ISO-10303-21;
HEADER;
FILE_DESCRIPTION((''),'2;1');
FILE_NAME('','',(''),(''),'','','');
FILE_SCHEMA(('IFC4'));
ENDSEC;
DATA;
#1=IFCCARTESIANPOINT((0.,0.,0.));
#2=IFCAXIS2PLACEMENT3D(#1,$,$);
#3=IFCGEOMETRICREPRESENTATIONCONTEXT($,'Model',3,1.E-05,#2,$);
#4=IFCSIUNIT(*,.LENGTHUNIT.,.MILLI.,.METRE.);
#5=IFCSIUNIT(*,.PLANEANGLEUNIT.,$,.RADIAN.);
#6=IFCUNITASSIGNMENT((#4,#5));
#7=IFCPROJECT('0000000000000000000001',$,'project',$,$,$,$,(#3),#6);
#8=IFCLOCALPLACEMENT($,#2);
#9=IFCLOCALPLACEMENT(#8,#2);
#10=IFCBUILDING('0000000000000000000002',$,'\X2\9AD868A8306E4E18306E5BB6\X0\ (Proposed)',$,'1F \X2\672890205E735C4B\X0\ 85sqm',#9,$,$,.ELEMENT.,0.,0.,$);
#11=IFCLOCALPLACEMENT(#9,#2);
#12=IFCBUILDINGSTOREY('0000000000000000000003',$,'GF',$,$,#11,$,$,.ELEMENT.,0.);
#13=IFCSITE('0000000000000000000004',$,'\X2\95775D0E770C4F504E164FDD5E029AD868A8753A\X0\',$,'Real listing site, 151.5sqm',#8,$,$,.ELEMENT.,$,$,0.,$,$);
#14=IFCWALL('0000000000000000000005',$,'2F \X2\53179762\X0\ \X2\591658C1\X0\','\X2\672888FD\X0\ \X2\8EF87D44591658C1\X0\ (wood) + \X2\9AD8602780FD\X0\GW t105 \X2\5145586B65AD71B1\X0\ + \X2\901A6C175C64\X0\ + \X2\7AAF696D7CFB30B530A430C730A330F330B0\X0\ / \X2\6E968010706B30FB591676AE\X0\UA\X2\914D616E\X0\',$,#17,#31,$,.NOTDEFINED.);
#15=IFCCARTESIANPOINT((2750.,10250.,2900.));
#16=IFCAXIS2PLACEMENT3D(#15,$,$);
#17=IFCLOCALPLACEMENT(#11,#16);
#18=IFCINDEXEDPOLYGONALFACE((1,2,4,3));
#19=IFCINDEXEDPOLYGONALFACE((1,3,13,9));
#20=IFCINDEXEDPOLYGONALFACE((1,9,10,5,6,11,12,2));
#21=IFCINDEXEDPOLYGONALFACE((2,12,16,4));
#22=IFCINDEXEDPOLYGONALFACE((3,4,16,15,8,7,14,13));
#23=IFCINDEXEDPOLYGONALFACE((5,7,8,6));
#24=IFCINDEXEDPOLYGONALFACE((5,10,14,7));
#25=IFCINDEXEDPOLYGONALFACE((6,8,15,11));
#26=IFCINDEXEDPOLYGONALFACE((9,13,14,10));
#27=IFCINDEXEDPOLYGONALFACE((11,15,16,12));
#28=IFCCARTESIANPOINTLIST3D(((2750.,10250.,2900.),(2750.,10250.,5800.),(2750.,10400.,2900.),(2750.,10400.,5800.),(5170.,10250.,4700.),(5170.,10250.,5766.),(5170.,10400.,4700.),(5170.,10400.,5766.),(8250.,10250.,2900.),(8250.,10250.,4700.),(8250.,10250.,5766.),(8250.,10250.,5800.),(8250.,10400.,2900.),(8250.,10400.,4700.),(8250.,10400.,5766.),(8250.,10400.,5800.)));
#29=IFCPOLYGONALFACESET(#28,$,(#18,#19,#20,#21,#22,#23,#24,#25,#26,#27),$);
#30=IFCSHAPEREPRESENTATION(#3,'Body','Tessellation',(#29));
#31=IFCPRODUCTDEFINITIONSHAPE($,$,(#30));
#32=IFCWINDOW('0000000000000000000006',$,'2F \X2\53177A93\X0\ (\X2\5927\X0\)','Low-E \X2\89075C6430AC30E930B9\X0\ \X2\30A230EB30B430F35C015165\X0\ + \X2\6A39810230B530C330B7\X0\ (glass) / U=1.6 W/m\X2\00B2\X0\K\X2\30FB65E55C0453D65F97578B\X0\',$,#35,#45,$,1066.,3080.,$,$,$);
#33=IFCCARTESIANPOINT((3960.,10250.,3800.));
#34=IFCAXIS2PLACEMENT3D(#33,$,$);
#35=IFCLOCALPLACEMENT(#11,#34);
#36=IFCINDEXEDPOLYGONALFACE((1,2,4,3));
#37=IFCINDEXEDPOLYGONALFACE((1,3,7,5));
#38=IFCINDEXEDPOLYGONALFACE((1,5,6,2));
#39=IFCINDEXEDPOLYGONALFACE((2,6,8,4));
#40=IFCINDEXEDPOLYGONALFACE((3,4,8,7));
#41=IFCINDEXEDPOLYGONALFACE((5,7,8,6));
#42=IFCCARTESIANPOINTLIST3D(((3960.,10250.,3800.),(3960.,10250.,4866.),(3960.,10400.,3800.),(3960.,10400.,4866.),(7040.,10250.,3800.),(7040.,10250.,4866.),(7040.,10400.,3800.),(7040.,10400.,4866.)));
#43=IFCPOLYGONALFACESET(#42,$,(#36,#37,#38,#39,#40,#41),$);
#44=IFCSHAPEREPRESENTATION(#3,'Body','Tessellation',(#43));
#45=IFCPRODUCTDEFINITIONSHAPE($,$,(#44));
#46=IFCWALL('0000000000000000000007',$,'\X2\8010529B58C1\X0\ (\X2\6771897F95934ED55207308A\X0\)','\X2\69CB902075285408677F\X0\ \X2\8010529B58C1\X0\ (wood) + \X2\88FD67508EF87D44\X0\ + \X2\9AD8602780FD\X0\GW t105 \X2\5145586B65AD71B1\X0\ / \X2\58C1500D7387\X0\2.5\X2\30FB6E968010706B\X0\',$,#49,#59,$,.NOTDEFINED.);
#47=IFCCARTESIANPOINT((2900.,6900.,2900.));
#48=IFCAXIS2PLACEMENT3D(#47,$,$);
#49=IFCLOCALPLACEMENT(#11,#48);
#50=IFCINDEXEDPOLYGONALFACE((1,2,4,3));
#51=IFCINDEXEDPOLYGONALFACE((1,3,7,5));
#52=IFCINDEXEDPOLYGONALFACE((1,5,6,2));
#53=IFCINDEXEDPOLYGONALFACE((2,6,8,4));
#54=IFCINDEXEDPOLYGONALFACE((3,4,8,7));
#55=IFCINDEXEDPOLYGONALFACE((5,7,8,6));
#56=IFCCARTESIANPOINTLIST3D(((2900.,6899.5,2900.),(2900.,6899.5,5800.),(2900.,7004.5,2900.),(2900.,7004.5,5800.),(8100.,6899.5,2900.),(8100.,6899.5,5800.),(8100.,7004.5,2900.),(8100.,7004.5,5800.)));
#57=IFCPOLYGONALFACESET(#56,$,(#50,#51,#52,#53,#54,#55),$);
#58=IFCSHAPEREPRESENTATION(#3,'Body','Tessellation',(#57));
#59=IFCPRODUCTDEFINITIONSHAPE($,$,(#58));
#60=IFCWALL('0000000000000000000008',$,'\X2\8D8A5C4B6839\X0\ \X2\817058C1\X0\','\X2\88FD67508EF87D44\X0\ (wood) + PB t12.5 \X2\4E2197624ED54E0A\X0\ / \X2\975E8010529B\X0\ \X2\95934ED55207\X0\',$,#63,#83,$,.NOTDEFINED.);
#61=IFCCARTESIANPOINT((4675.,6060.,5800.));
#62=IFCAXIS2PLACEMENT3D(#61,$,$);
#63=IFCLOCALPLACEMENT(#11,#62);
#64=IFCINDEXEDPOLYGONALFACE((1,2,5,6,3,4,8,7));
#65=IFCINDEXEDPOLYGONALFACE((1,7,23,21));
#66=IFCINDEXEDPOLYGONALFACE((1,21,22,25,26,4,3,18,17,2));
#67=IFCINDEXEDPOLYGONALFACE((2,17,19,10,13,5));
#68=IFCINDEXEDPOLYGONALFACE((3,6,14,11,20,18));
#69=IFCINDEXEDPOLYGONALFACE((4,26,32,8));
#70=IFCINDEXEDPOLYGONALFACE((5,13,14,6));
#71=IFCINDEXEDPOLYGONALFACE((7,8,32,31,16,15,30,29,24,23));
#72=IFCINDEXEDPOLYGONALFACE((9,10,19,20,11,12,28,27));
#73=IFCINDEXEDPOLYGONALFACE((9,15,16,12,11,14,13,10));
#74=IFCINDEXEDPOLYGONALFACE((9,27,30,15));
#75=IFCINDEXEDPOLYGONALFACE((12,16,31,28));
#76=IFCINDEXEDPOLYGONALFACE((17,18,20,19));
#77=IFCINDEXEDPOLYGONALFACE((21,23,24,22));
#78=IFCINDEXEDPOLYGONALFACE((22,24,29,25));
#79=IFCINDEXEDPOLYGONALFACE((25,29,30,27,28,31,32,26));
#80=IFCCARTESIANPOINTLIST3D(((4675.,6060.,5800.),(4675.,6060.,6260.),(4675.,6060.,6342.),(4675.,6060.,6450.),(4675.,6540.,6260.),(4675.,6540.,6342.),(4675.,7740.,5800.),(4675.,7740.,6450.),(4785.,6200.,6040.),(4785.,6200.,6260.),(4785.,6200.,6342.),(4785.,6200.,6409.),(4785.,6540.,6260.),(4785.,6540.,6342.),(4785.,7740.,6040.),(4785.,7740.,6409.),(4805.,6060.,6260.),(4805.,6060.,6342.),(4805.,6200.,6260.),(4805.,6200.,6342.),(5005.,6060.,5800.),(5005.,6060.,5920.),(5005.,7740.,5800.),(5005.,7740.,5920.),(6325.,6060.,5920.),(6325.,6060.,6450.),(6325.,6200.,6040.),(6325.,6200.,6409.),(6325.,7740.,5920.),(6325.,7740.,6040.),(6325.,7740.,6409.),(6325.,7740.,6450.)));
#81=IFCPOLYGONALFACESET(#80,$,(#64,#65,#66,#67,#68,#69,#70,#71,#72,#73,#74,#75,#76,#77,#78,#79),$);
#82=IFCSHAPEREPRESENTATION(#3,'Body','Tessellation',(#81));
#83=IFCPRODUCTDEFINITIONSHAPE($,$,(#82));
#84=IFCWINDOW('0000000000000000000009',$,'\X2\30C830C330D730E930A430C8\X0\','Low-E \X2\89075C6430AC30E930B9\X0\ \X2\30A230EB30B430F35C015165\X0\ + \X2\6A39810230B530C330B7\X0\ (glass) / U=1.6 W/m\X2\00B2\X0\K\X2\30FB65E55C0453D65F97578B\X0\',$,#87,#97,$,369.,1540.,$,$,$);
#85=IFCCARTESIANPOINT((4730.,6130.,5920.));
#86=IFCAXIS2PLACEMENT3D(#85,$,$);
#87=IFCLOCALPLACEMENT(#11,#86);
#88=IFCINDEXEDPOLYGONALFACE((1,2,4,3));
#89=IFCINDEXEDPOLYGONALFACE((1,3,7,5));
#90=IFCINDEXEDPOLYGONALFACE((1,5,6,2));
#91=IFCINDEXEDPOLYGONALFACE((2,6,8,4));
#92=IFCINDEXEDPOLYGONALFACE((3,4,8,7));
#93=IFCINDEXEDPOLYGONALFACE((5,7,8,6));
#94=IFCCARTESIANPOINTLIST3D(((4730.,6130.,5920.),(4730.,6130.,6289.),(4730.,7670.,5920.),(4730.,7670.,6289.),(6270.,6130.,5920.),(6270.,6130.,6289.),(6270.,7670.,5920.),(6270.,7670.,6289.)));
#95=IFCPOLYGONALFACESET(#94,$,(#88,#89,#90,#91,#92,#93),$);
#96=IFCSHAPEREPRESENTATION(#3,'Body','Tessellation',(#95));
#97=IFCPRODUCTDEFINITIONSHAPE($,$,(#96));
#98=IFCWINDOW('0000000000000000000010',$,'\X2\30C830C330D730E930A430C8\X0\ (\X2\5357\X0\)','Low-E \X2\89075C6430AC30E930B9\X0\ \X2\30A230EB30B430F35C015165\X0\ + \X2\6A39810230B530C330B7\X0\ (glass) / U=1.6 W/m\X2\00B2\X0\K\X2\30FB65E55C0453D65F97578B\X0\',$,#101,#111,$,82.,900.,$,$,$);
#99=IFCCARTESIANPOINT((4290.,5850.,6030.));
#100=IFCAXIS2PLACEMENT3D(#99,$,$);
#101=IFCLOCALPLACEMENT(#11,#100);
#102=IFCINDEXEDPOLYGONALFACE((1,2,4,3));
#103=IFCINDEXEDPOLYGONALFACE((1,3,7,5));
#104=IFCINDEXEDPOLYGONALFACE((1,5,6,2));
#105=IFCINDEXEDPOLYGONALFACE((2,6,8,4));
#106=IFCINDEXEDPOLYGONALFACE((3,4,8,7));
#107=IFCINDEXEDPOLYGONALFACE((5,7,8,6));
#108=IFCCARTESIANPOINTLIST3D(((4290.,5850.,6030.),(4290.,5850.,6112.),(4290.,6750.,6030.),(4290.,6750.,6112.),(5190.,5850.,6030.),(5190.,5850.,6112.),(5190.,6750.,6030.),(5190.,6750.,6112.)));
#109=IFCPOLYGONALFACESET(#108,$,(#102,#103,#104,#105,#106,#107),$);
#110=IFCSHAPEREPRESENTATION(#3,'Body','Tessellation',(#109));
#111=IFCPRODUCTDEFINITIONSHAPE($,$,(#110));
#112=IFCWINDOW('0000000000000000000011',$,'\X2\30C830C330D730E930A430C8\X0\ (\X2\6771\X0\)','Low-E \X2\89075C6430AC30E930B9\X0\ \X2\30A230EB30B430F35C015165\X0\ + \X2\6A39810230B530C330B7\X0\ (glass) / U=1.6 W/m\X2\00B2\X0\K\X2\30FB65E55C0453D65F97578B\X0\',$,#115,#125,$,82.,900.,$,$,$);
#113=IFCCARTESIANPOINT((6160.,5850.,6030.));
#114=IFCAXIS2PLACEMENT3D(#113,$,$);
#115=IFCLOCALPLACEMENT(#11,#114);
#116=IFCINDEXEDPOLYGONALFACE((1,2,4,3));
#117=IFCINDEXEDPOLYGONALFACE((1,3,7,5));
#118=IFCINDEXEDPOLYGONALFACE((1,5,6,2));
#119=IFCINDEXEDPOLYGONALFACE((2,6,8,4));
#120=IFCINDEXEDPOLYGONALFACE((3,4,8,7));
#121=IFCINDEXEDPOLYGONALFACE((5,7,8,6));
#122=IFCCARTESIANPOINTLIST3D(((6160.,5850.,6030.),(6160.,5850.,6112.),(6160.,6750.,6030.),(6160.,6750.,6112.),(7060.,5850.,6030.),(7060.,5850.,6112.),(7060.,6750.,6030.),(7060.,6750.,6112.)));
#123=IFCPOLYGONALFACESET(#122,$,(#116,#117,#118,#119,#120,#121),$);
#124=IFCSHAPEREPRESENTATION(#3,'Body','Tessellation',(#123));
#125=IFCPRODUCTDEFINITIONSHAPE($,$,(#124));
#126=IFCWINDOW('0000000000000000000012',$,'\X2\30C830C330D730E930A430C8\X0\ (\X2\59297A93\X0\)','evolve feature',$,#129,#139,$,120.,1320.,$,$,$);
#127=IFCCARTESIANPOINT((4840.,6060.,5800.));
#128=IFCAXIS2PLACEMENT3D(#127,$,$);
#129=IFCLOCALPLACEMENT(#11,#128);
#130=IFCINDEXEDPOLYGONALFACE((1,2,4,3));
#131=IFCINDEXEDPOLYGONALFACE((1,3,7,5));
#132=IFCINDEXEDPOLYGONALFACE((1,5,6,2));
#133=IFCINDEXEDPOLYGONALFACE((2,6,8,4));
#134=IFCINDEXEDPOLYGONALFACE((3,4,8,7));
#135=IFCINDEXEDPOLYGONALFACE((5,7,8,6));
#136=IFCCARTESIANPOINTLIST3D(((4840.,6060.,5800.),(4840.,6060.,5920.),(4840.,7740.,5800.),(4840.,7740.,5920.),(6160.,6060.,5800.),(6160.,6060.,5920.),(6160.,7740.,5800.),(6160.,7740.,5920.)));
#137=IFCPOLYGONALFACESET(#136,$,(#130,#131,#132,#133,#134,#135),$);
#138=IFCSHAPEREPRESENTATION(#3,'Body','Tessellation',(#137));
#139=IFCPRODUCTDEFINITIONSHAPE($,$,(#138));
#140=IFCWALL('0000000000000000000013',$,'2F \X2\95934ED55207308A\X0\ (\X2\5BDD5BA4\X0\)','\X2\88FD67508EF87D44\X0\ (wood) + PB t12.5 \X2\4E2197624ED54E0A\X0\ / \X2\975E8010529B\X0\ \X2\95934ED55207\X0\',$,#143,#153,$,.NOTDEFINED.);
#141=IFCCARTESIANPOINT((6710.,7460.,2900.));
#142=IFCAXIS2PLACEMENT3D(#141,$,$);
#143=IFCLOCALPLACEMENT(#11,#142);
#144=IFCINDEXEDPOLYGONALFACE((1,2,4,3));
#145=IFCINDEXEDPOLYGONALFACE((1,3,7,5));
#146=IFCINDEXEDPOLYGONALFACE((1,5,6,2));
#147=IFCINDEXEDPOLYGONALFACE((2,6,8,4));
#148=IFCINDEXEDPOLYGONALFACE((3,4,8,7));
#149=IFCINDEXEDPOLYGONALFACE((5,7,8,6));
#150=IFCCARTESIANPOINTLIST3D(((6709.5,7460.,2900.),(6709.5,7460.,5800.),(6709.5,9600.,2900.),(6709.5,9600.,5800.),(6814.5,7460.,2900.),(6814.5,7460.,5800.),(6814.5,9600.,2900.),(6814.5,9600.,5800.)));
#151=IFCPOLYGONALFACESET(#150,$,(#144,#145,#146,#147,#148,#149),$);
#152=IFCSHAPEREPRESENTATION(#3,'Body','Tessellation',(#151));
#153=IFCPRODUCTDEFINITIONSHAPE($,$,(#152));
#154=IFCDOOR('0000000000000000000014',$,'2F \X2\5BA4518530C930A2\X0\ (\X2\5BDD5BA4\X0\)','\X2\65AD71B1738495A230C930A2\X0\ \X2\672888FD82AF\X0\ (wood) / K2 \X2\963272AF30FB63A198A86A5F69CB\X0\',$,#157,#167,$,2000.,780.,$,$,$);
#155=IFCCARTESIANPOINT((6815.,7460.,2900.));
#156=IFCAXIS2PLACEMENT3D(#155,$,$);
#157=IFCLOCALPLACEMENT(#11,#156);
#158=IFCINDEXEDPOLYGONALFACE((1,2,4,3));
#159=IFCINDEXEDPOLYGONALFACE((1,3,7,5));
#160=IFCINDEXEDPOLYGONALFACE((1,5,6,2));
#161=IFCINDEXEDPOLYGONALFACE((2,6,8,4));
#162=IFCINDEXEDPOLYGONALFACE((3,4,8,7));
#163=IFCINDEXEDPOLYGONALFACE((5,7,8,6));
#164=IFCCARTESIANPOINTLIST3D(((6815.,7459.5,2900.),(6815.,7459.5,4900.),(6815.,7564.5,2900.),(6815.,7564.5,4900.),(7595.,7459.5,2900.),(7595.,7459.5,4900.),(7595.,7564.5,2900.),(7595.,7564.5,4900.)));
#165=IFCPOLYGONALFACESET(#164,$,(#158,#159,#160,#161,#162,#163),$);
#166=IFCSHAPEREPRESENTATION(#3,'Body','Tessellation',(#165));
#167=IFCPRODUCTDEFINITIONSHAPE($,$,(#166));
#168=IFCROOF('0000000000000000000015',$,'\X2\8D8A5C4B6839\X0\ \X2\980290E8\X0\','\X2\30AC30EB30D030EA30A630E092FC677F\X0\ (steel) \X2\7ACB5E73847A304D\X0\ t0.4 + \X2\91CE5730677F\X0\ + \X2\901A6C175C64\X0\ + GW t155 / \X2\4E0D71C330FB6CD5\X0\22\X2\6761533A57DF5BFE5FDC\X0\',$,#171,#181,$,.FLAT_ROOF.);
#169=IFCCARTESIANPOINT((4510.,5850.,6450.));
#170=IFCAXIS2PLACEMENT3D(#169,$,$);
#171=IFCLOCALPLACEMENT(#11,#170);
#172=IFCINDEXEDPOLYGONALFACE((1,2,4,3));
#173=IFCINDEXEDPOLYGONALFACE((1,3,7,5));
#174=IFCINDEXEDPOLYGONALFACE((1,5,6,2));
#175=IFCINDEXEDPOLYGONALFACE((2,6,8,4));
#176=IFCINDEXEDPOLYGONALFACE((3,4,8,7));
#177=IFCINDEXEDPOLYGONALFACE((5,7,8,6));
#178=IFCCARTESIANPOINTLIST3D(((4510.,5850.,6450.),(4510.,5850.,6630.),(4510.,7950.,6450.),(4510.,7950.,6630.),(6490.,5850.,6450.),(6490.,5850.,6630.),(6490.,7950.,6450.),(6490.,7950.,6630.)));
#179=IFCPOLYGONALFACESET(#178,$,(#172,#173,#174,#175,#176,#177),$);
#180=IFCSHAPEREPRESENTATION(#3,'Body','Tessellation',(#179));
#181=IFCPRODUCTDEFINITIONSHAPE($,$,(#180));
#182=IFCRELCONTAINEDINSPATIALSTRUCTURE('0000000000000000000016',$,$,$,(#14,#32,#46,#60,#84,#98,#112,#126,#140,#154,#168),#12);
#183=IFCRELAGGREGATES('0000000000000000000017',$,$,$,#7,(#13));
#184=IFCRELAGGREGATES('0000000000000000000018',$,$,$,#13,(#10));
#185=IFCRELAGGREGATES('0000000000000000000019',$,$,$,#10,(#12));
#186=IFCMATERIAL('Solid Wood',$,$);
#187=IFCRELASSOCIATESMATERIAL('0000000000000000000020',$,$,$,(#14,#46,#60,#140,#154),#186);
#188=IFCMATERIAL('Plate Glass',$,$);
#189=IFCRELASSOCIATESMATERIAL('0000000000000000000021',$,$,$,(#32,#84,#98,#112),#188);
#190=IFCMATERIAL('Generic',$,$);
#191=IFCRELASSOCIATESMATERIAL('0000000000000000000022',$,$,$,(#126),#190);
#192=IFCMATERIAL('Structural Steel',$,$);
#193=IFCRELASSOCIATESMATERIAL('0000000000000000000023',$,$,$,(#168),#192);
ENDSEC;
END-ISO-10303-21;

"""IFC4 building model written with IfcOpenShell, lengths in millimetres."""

from ifc_helpers import new_model, si_unit, frame, frame_2d, origin, place, context, project, spatial, rectangle, extrude, material, element, fill, save


model = new_model("IFC4")

# Units and contexts
model_context = context("Model", 3, precision=1e-05, world=origin())
ifc_project = project(units=[si_unit("LENGTHUNIT", "METRE", prefix="MILLI"), si_unit("PLANEANGLEUNIT", "RADIAN")], contexts=[model_context])

# Site, building, storey
site_placement = place(None, origin())
site = spatial("IfcSite", under=ifc_project, at=site_placement, Name="長崎県佐世保市高梨町", ObjectType="Real listing site, 151.5sqm", CompositionType="ELEMENT", RefElevation=0.0)
building_placement = place(site_placement, origin())
building = spatial("IfcBuilding", under=site, at=building_placement, Name="高梨の丘の家 (Proposed)", ObjectType="1F 木造平屋 85sqm", CompositionType="ELEMENT", ElevationOfRefHeight=0.0, ElevationOfTerrain=0.0)
storey_placement = place(building_placement, origin())
storey = spatial("IfcBuildingStorey", under=building, at=storey_placement, Name="GF", CompositionType="ELEMENT", Elevation=0.0)

# Wall, opening, window
ifc_material_1 = material(Name="Solid Wood")
wall_1_placement = place(storey_placement, frame((2750.0, 10250.0, 2900.0)))
wall_1 = element("IfcWall", 1, at=wall_1_placement, inside=storey, material=ifc_material_1, Name="2F 北面 外壁", Description="木製 軸組外壁 (wood) + 高性能GW t105 充填断熱 + 通気層 + 窯業系サイディング / 準耐火・外皮UA配慮", PredefinedType="NOTDEFINED", context=model_context, shape_type="SweptSolid", body=[
    extrude(rectangle(XDim=5500.0, YDim=150.0, at=frame_2d((2750.0, 75.0))), frame((2750.0, 10250.0, 2900.0)), (0.0, 0.0, 1.0), 2900.0),
])
opening_1_placement = place(storey_placement, frame((3960.0, 10250.0, 3800.0)))
opening_1 = element("IfcOpeningElement", 2, at=opening_1_placement, cuts=wall_1, PredefinedType="NOTDEFINED", context=model_context, shape_type="SweptSolid", body=[
    extrude(rectangle(XDim=3080.0, YDim=150.0, at=frame_2d((1540.0, 75.0))), frame((3960.0, 10250.0, 3800.0)), (0.0, 0.0, 1.0), 1066.0),
])
ifc_material_2 = material(Name="Plate Glass")
window_1_placement = place(storey_placement, frame((3960.0, 10250.0, 3800.0)))
window_1 = element("IfcWindow", 3, at=window_1_placement, inside=storey, material=ifc_material_2, Name="2F 北窓 (大)", Description="Low-E 複層ガラス アルゴン封入 + 樹脂サッシ (glass) / U=1.6 W/m²K・日射取得型", OverallHeight=1066.0, OverallWidth=3080.0, context=model_context, shape_type="SweptSolid", body=[
    extrude(rectangle(XDim=3080.0, YDim=150.0, at=frame_2d((1540.0, 75.0))), frame((3960.0, 10250.0, 3800.0)), (0.0, 0.0, 1.0), 1066.0),
])
fill(opening_1, window_1)

# Wall
wall_2_placement = place(storey_placement, frame((2900.0, 6900.0, 2900.0)))
element("IfcWall", 4, at=wall_2_placement, inside=storey, material=ifc_material_1, Name="耐力壁 (東西間仕切り)", Description="構造用合板 耐力壁 (wood) + 製材軸組 + 高性能GW t105 充填断熱 / 壁倍率2.5・準耐火", PredefinedType="NOTDEFINED", context=model_context, shape_type="SweptSolid", body=[
    extrude(rectangle(XDim=5200.0, YDim=105.0, at=frame_2d((2600.0, 52.0))), frame((2900.0, 6900.0, 2900.0)), (0.0, 0.0, 1.0), 2900.0),
])

# Wall, openings, windows
wall_3_placement = place(storey_placement, frame((4675.0, 6060.0, 5800.0)))
wall_3 = element("IfcWall", 5, at=wall_3_placement, inside=storey, material=ifc_material_1, Name="越屋根 腰壁", Description="製材軸組 (wood) + PB t12.5 両面仕上 / 非耐力 間仕切", PredefinedType="NOTDEFINED", context=model_context, shape_type="SweptSolid", body=[
    extrude(rectangle(XDim=1650.0, YDim=1680.0, at=frame_2d((825.0, 840.0))), frame((4675.0, 6060.0, 5800.0)), (0.0, 0.0, 1.0), 650.0),
])
opening_2_placement = place(storey_placement, frame((4730.0, 6130.0, 5920.0)))
opening_2 = element("IfcOpeningElement", 6, at=opening_2_placement, cuts=wall_3, PredefinedType="NOTDEFINED", context=model_context, shape_type="SweptSolid", body=[
    extrude(rectangle(XDim=1540.0, YDim=1540.0, at=frame_2d((770.0, 770.0))), frame((4730.0, 6130.0, 5920.0)), (0.0, 0.0, 1.0), 369.0),
])
opening_3_placement = place(storey_placement, frame((4290.0, 5850.0, 6030.0)))
opening_3 = element("IfcOpeningElement", 7, at=opening_3_placement, cuts=wall_3, PredefinedType="NOTDEFINED", context=model_context, shape_type="SweptSolid", body=[
    extrude(rectangle(XDim=900.0, YDim=900.0, at=frame_2d((450.0, 450.0))), frame((4290.0, 5850.0, 6030.0)), (0.0, 0.0, 1.0), 82.0),
])
opening_4_placement = place(storey_placement, frame((6160.0, 5850.0, 6030.0)))
opening_4 = element("IfcOpeningElement", 8, at=opening_4_placement, cuts=wall_3, PredefinedType="NOTDEFINED", context=model_context, shape_type="SweptSolid", body=[
    extrude(rectangle(XDim=900.0, YDim=900.0, at=frame_2d((450.0, 450.0))), frame((6160.0, 5850.0, 6030.0)), (0.0, 0.0, 1.0), 82.0),
])
opening_5_placement = place(storey_placement, frame((4840.0, 6060.0, 5800.0)))
opening_5 = element("IfcOpeningElement", 9, at=opening_5_placement, cuts=wall_3, PredefinedType="NOTDEFINED", context=model_context, shape_type="SweptSolid", body=[
    extrude(rectangle(XDim=1320.0, YDim=1680.0, at=frame_2d((660.0, 840.0))), frame((4840.0, 6060.0, 5800.0)), (0.0, 0.0, 1.0), 120.0),
])
window_2_placement = place(storey_placement, frame((4730.0, 6130.0, 5920.0)))
window_2 = element("IfcWindow", 10, at=window_2_placement, inside=storey, material=ifc_material_2, Name="トップライト", Description="Low-E 複層ガラス アルゴン封入 + 樹脂サッシ (glass) / U=1.6 W/m²K・日射取得型", OverallHeight=369.0, OverallWidth=1540.0, context=model_context, shape_type="SweptSolid", body=[
    extrude(rectangle(XDim=1540.0, YDim=1540.0, at=frame_2d((770.0, 770.0))), frame((4730.0, 6130.0, 5920.0)), (0.0, 0.0, 1.0), 369.0),
])
fill(opening_2, window_2)
window_3_placement = place(storey_placement, frame((4290.0, 5850.0, 6030.0)))
window_3 = element("IfcWindow", 11, at=window_3_placement, inside=storey, material=ifc_material_2, Name="トップライト (南)", Description="Low-E 複層ガラス アルゴン封入 + 樹脂サッシ (glass) / U=1.6 W/m²K・日射取得型", OverallHeight=82.0, OverallWidth=900.0, context=model_context, shape_type="SweptSolid", body=[
    extrude(rectangle(XDim=900.0, YDim=900.0, at=frame_2d((450.0, 450.0))), frame((4290.0, 5850.0, 6030.0)), (0.0, 0.0, 1.0), 82.0),
])
fill(opening_3, window_3)
window_4_placement = place(storey_placement, frame((6160.0, 5850.0, 6030.0)))
window_4 = element("IfcWindow", 12, at=window_4_placement, inside=storey, material=ifc_material_2, Name="トップライト (東)", Description="Low-E 複層ガラス アルゴン封入 + 樹脂サッシ (glass) / U=1.6 W/m²K・日射取得型", OverallHeight=82.0, OverallWidth=900.0, context=model_context, shape_type="SweptSolid", body=[
    extrude(rectangle(XDim=900.0, YDim=900.0, at=frame_2d((450.0, 450.0))), frame((6160.0, 5850.0, 6030.0)), (0.0, 0.0, 1.0), 82.0),
])
fill(opening_4, window_4)
ifc_material_3 = material(Name="Generic")
window_5_placement = place(storey_placement, frame((4840.0, 6060.0, 5800.0)))
window_5 = element("IfcWindow", 13, at=window_5_placement, inside=storey, material=ifc_material_3, Name="トップライト (天窓)", Description="evolve feature", OverallHeight=120.0, OverallWidth=1320.0, context=model_context, shape_type="SweptSolid", body=[
    extrude(rectangle(XDim=1320.0, YDim=1680.0, at=frame_2d((660.0, 840.0))), frame((4840.0, 6060.0, 5800.0)), (0.0, 0.0, 1.0), 120.0),
])
fill(opening_5, window_5)

# Wall
wall_4_placement = place(storey_placement, frame((6710.0, 7460.0, 2900.0)))
element("IfcWall", 14, at=wall_4_placement, inside=storey, material=ifc_material_1, Name="2F 間仕切り (寝室)", Description="製材軸組 (wood) + PB t12.5 両面仕上 / 非耐力 間仕切", PredefinedType="NOTDEFINED", context=model_context, shape_type="SweptSolid", body=[
    extrude(rectangle(XDim=105.0, YDim=2140.0, at=frame_2d((52.0, 1070.0))), frame((6710.0, 7460.0, 2900.0)), (0.0, 0.0, 1.0), 2900.0),
])

# Door
door_placement = place(storey_placement, frame((6815.0, 7460.0, 2900.0)))
element("IfcDoor", 15, at=door_placement, inside=storey, material=ifc_material_1, Name="2F 室内ドア (寝室)", Description="断熱玄関ドア 木製芯 (wood) / K2 防犯・採風機構", OverallHeight=2000.0, OverallWidth=780.0, context=model_context, shape_type="SweptSolid", body=[
    extrude(rectangle(XDim=780.0, YDim=105.0, at=frame_2d((390.0, 52.0))), frame((6815.0, 7460.0, 2900.0)), (0.0, 0.0, 1.0), 2000.0),
])

# Roof
ifc_material_4 = material(Name="Structural Steel")
roof_placement = place(storey_placement, frame((4510.0, 5850.0, 6450.0)))
element("IfcRoof", 16, at=roof_placement, inside=storey, material=ifc_material_4, Name="越屋根 頂部", Description="ガルバリウム鋼板 (steel) 立平葺き t0.4 + 野地板 + 通気層 + GW t155 / 不燃・法22条区域対応", PredefinedType="FLAT_ROOF", context=model_context, shape_type="SweptSolid", body=[
    extrude(rectangle(XDim=1980.0, YDim=2100.0, at=frame_2d((990.0, 1050.0))), frame((4510.0, 5850.0, 6450.0)), (0.0, 0.0, 1.0), 180.0),
])

save(model, "model.ifc")
